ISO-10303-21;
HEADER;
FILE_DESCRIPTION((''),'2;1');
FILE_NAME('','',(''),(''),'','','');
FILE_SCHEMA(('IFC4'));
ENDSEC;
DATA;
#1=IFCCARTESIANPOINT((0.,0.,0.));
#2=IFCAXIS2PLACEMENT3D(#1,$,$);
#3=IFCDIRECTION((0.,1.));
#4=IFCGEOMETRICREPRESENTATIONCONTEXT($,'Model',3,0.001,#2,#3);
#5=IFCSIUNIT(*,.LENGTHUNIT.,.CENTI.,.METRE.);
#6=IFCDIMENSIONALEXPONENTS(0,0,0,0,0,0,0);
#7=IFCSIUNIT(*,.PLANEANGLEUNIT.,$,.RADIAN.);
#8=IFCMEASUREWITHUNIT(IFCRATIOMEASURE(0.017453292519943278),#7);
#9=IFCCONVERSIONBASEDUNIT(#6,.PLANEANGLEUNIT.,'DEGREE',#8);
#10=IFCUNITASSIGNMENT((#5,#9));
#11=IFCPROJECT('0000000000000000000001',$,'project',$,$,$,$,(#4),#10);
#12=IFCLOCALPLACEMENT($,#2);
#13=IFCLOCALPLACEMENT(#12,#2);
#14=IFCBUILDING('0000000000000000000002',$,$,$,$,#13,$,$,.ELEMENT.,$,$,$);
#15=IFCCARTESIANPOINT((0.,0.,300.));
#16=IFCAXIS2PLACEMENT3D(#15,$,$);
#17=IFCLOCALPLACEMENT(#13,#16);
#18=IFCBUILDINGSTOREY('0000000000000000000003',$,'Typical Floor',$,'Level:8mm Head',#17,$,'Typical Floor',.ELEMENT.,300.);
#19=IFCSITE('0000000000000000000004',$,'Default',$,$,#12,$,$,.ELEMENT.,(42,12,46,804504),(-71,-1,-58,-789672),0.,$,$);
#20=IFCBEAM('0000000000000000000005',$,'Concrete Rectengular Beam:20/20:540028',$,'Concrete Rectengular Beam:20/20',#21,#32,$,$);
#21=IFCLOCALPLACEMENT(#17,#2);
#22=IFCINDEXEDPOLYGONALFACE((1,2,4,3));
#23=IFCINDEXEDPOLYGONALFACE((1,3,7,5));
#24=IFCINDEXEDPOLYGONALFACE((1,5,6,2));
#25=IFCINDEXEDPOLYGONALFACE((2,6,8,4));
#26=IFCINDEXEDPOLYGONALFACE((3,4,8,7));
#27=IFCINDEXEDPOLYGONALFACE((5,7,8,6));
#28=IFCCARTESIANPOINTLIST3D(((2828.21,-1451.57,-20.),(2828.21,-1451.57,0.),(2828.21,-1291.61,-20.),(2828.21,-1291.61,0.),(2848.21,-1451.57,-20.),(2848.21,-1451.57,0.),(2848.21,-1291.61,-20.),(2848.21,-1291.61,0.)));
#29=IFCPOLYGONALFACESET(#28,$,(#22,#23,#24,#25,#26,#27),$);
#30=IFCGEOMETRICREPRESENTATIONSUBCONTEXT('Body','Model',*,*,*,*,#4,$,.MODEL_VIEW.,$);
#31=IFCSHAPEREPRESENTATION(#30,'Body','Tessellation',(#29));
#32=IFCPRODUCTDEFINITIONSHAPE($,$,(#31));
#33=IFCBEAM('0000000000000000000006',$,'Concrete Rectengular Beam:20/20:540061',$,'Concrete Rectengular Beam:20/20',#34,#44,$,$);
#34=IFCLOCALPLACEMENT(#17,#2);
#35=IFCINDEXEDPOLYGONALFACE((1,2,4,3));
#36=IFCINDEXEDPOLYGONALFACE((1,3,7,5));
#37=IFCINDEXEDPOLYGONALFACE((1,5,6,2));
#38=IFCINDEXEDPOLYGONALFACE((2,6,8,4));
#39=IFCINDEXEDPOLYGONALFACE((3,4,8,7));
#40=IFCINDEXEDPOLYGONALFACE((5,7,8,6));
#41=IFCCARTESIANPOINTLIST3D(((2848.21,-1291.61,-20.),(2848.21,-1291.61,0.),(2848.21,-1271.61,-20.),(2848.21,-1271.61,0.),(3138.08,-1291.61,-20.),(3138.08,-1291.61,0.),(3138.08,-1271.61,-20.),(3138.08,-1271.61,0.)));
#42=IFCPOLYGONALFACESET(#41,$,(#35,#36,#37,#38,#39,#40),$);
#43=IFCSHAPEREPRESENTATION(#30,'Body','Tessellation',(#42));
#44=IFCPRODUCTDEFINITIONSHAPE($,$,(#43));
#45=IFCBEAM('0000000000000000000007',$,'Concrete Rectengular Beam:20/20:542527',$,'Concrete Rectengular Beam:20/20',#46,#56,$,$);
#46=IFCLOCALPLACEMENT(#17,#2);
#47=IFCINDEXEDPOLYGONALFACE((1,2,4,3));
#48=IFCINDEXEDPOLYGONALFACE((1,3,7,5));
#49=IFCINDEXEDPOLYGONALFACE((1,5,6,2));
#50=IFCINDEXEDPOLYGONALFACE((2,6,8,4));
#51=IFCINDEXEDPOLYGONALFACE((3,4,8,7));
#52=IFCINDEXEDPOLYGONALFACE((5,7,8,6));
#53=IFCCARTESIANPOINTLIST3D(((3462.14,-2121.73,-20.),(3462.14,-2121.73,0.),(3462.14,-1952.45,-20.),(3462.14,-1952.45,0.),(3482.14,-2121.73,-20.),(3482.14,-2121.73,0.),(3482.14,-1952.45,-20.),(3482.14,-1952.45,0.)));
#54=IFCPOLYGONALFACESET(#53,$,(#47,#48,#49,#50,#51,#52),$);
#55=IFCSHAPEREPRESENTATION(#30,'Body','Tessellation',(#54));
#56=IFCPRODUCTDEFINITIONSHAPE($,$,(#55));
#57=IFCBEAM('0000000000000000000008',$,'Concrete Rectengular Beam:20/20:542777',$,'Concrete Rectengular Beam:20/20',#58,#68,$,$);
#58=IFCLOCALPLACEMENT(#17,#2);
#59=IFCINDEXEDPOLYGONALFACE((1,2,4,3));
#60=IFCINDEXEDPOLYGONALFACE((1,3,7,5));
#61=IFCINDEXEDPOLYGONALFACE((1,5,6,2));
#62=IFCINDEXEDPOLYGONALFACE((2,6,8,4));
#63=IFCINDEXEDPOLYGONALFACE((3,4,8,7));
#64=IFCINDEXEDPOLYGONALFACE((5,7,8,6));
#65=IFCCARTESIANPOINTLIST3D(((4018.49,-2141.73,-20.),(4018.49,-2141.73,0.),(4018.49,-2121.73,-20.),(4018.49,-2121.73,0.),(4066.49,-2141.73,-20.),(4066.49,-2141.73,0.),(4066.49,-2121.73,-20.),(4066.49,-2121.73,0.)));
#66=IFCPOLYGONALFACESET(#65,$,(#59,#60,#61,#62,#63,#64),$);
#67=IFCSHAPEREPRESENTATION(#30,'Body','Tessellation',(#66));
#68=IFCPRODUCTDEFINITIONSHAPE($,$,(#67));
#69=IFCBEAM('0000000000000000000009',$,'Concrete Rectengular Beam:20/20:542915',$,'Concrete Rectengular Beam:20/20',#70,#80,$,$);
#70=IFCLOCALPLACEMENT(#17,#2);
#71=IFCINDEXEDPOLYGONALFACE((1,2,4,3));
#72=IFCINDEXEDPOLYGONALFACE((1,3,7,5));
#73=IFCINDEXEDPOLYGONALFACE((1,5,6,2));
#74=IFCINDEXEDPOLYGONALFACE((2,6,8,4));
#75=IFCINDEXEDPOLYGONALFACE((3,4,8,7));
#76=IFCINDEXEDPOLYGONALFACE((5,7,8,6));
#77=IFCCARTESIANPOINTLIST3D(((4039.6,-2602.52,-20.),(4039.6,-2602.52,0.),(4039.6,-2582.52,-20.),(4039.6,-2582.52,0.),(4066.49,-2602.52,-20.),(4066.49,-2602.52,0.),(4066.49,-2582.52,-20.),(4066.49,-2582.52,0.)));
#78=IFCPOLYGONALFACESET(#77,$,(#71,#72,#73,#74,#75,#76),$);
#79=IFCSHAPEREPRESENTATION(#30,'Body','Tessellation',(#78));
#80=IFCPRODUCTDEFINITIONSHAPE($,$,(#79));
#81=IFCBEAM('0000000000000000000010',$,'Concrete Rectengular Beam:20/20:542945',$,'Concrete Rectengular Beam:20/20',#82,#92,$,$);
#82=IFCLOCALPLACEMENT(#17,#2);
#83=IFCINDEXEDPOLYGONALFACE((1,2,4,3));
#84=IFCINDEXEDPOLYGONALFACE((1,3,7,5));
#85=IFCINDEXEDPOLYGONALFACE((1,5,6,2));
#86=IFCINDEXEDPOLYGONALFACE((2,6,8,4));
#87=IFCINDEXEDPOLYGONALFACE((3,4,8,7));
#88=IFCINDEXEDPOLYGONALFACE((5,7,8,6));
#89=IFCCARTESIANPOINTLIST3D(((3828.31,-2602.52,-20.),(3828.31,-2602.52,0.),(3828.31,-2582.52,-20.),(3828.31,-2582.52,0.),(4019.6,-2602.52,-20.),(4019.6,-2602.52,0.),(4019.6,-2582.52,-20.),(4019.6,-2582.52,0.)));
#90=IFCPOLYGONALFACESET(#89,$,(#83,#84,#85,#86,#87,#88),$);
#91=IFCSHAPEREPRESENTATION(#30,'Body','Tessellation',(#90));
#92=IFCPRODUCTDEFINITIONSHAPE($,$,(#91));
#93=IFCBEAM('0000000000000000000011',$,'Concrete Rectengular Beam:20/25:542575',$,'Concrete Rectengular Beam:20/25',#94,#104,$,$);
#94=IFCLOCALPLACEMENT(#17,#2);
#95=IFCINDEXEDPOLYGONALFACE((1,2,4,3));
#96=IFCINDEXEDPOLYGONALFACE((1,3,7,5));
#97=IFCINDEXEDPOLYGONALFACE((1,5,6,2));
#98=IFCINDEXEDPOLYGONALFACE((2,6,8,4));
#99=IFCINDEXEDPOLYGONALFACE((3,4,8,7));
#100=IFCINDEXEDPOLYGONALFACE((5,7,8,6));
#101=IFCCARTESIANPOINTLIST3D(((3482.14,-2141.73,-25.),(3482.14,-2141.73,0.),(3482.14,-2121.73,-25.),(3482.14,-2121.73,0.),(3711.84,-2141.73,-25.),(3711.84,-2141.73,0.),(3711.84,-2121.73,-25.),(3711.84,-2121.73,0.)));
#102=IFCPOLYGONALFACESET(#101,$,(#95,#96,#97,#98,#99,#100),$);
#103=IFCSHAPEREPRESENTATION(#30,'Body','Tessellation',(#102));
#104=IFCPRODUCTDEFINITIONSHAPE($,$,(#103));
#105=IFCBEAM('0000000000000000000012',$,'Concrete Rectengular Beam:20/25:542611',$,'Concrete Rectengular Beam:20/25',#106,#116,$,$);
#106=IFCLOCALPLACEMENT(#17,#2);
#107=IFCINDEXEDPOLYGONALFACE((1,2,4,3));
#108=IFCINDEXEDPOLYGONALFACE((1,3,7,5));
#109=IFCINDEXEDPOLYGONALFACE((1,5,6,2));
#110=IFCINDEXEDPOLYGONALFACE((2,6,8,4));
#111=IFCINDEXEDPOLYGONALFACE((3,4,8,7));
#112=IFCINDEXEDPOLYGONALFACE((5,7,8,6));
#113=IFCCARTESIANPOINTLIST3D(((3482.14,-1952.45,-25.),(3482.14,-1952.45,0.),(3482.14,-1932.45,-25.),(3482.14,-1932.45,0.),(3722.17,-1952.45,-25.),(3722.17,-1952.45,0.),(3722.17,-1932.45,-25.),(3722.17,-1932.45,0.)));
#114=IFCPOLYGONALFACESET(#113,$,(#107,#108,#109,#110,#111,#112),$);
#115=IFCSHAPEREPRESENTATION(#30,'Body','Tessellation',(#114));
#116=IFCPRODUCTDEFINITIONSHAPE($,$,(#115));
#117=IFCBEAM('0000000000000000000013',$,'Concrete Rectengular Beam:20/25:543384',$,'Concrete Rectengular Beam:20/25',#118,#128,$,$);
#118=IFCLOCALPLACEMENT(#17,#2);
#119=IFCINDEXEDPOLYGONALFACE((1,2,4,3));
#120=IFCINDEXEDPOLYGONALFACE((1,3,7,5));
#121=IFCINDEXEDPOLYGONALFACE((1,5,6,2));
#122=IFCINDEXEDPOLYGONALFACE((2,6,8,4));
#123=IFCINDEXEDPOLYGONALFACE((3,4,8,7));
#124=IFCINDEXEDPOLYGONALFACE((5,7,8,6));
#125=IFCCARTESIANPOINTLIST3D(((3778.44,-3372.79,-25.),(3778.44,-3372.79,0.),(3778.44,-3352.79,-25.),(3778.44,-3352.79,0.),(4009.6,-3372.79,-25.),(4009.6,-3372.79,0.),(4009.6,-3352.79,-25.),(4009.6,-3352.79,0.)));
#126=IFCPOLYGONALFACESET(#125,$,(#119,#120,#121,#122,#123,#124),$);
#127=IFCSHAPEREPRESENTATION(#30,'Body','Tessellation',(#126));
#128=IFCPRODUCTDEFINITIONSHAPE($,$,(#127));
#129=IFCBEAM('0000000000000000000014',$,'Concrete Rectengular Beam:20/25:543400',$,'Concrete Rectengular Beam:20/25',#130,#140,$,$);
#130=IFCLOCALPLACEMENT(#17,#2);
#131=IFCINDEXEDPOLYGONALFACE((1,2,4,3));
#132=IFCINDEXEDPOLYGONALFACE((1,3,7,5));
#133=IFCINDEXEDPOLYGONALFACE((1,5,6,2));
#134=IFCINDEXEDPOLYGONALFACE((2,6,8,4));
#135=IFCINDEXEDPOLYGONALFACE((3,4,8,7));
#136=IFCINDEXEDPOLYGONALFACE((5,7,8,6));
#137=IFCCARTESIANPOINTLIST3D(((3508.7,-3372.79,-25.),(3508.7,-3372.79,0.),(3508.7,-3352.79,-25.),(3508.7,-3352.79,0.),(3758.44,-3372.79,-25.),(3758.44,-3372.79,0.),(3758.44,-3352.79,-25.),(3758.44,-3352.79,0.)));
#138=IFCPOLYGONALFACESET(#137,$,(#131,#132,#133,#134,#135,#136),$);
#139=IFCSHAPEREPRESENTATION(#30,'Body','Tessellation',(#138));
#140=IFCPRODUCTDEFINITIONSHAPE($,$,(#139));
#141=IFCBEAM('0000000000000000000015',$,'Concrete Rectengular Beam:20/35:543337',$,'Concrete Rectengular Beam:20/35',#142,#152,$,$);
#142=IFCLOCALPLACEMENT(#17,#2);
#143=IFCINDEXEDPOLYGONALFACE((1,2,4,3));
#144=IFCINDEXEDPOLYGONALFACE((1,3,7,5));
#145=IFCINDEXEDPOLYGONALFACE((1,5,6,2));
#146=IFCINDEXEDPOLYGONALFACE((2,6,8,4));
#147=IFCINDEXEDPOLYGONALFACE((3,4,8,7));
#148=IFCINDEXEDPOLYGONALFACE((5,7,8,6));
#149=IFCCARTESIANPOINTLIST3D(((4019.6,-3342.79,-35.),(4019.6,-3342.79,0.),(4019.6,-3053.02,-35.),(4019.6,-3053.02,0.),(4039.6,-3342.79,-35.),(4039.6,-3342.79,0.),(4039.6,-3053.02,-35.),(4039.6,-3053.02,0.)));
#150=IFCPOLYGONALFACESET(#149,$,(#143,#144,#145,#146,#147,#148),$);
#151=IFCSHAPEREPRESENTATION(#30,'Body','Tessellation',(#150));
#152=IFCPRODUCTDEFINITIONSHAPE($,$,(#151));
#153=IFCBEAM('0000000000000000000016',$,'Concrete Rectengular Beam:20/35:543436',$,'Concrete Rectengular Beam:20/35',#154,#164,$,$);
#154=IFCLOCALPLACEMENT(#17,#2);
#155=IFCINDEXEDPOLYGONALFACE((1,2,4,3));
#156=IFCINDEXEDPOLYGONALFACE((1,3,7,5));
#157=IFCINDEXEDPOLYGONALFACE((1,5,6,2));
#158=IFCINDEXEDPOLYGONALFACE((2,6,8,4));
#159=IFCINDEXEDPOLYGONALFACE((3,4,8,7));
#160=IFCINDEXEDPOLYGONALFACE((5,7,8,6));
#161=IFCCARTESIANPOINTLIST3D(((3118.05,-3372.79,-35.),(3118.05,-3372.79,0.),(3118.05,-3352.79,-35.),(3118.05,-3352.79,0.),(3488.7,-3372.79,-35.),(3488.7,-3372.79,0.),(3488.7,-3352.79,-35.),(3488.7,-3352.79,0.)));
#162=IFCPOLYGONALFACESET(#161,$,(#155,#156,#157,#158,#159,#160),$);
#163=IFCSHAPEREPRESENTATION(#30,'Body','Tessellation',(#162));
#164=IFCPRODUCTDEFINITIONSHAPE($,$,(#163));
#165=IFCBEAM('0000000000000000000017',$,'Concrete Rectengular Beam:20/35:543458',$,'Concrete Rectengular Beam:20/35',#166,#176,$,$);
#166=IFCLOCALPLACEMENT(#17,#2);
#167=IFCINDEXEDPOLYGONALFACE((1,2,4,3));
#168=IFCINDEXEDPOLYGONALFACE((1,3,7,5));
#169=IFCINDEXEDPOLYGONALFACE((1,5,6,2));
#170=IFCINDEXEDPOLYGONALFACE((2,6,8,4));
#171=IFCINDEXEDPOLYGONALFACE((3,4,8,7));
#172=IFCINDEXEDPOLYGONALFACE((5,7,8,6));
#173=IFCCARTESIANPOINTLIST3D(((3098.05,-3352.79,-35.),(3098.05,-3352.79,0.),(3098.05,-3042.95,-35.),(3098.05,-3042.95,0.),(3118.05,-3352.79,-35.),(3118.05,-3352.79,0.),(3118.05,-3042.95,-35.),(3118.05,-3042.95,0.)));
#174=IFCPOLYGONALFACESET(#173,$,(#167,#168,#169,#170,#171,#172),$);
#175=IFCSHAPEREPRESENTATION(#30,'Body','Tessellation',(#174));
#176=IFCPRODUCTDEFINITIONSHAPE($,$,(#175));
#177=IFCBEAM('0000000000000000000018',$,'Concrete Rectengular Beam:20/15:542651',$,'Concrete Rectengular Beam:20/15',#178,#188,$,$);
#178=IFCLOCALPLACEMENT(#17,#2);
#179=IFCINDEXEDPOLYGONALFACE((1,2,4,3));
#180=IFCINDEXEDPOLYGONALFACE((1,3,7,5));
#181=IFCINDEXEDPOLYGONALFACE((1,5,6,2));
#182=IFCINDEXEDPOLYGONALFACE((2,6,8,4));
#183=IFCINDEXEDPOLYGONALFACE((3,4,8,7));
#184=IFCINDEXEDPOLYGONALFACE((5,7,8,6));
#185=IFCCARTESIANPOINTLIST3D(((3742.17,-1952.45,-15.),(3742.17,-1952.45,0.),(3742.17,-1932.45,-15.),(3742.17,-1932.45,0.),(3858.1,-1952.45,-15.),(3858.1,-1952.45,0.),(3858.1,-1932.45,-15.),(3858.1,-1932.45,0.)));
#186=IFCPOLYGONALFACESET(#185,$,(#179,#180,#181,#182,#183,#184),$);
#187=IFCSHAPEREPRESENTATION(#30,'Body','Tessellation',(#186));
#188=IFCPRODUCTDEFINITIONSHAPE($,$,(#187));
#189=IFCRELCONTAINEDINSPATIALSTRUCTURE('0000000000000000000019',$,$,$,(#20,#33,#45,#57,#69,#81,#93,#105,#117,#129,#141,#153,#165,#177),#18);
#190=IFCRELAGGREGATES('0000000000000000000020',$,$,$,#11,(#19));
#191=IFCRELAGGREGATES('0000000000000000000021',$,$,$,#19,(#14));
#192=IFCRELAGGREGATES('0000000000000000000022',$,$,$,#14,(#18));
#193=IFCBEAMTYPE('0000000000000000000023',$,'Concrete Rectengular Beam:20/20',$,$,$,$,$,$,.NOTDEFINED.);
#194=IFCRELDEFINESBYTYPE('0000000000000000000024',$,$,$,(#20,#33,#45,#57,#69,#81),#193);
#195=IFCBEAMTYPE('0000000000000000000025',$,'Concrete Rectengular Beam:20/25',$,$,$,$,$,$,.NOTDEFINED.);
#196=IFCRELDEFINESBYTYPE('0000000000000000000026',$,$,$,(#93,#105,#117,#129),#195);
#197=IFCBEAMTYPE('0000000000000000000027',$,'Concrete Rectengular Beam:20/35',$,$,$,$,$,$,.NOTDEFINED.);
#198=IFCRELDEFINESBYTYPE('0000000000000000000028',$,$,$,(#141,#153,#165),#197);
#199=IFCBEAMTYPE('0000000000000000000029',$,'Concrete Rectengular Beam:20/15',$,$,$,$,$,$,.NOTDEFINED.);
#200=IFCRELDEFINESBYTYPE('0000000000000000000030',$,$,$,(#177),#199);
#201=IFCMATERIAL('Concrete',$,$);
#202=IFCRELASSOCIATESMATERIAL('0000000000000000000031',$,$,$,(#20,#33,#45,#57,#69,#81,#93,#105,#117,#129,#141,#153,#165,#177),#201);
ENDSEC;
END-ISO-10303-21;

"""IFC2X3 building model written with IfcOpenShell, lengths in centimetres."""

from ifc_helpers import new_model, entity, si_unit, converted_unit, direction, frame, frame_2d, origin, place, context, subcontext, project, spatial, rectangle, extrude, material, type_object, element, save


model = new_model("IFC2X3")

# Units and contexts
model_context = context("Model", 3, precision=0.001, world=origin(), true_north=direction((0.0, 1.0)))
body_context = subcontext(model_context, "Body", "Model", "MODEL_VIEW")
ifc_project = project(units=[si_unit("LENGTHUNIT", "METRE", prefix="CENTI"), converted_unit("PLANEANGLEUNIT", "DEGREE", entity("IfcRatioMeasure", 0.017453292519943278), si_unit("PLANEANGLEUNIT", "RADIAN"), dimensions=[0, 0, 0, 0, 0, 0, 0])], contexts=[model_context])

# Site, building, storey
site_placement = place(None, origin())
site = spatial("IfcSite", under=ifc_project, at=site_placement, Name="Default", CompositionType="ELEMENT", RefLatitude=(42, 12, 46, 804504), RefLongitude=(-71, -1, -58, -789672), RefElevation=0.0)
building_placement = place(site_placement, origin())
building = spatial("IfcBuilding", under=site, at=building_placement, CompositionType="ELEMENT")
storey_placement = place(building_placement, frame((0.0, 0.0, 300.0)))
storey = spatial("IfcBuildingStorey", under=building, at=storey_placement, Name="Typical Floor", ObjectType="Level:8mm Head", LongName="Typical Floor", CompositionType="ELEMENT", Elevation=300.0)

# Beams
ifc_material = material(Name="Concrete")
beam_type_1 = type_object("IfcBeamType", Name="Concrete Rectengular Beam:20/20", PredefinedType="NOTDEFINED")
beam_1_placement = place(storey_placement, frame((2838.21, -1281.61, 0.0), z_axis=(0.0, 0.0, 1.0), x_axis=(0.0, -1.0, 0.0)))
element("IfcBeam", 1, at=beam_1_placement, inside=storey, type_object=beam_type_1, material=ifc_material, Name="Concrete Rectengular Beam:20/20:540028", ObjectType="Concrete Rectengular Beam:20/20", context=body_context, shape_type="SweptSolid", body=[
    extrude(rectangle(XDim=20.0, YDim=20.0, at=frame_2d((0.0, 0.0), x_axis=(1.0, 0.0))), frame((10.0, 0.0, -10.0), z_axis=(1.0, 0.0, 0.0), x_axis=(0.0, 0.0, -1.0)), (0.0, 0.0, 1.0), 159.96),
])
beam_2_placement = place(storey_placement, frame((2838.21, -1281.61, 0.0)))
element("IfcBeam", 2, at=beam_2_placement, inside=storey, type_object=beam_type_1, material=ifc_material, Name="Concrete Rectengular Beam:20/20:540061", ObjectType="Concrete Rectengular Beam:20/20", context=body_context, shape_type="SweptSolid", body=[
    extrude(rectangle(XDim=20.0, YDim=20.0, at=frame_2d((0.0, 0.0), x_axis=(1.0, 0.0))), frame((10.0, 0.0, -10.0), z_axis=(1.0, 0.0, 0.0), x_axis=(0.0, 0.0, -1.0)), (0.0, 0.0, 1.0), 289.88),
])
beam_3_placement = place(storey_placement, frame((3472.14, -2131.73, 0.0), z_axis=(0.0, 0.0, 1.0), x_axis=(0.0, 1.0, 0.0)))
element("IfcBeam", 3, at=beam_3_placement, inside=storey, type_object=beam_type_1, material=ifc_material, Name="Concrete Rectengular Beam:20/20:542527", ObjectType="Concrete Rectengular Beam:20/20", context=body_context, shape_type="SweptSolid", body=[
    extrude(rectangle(XDim=20.0, YDim=20.0, at=frame_2d((0.0, 0.0), x_axis=(1.0, 0.0))), frame((10.0, 0.0, -10.0), z_axis=(1.0, 0.0, 0.0), x_axis=(0.0, 0.0, -1.0)), (0.0, 0.0, 1.0), 169.28),
])
beam_4_placement = place(storey_placement, frame((3998.49, -2131.73, 0.0)))
element("IfcBeam", 4, at=beam_4_placement, inside=storey, type_object=beam_type_1, material=ifc_material, Name="Concrete Rectengular Beam:20/20:542777", ObjectType="Concrete Rectengular Beam:20/20", context=body_context, shape_type="SweptSolid", body=[
    extrude(rectangle(XDim=20.0, YDim=20.0, at=frame_2d((0.0, 0.0), x_axis=(1.0, 0.0))), frame((20.0, 0.0, -10.0), z_axis=(1.0, 0.0, 0.0), x_axis=(0.0, 0.0, -1.0)), (0.0, 0.0, 1.0), 48.0),
])
beam_5_placement = place(storey_placement, frame((4029.6, -2592.52, 0.0)))
element("IfcBeam", 5, at=beam_5_placement, inside=storey, type_object=beam_type_1, material=ifc_material, Name="Concrete Rectengular Beam:20/20:542915", ObjectType="Concrete Rectengular Beam:20/20", context=body_context, shape_type="SweptSolid", body=[
    extrude(rectangle(XDim=20.0, YDim=20.0, at=frame_2d((0.0, 0.0), x_axis=(1.0, 0.0))), frame((10.0, 0.0, -10.0), z_axis=(1.0, 0.0, 0.0), x_axis=(0.0, 0.0, -1.0)), (0.0, 0.0, 1.0), 26.89),
])
beam_6_placement = place(storey_placement, frame((4029.6, -2592.52, 0.0), z_axis=(0.0, 0.0, 1.0), x_axis=(-1.0, 0.0, 0.0)))
element("IfcBeam", 6, at=beam_6_placement, inside=storey, type_object=beam_type_1, material=ifc_material, Name="Concrete Rectengular Beam:20/20:542945", ObjectType="Concrete Rectengular Beam:20/20", context=body_context, shape_type="SweptSolid", body=[
    extrude(rectangle(XDim=20.0, YDim=20.0, at=frame_2d((0.0, 0.0), x_axis=(1.0, 0.0))), frame((10.0, 0.0, -10.0), z_axis=(1.0, 0.0, 0.0), x_axis=(0.0, 0.0, -1.0)), (0.0, 0.0, 1.0), 191.29),
])
beam_type_2 = type_object("IfcBeamType", Name="Concrete Rectengular Beam:20/25", PredefinedType="NOTDEFINED")
beam_7_placement = place(storey_placement, frame((3472.14, -2131.73, 0.0)))
element("IfcBeam", 7, at=beam_7_placement, inside=storey, type_object=beam_type_2, material=ifc_material, Name="Concrete Rectengular Beam:20/25:542575", ObjectType="Concrete Rectengular Beam:20/25", context=body_context, shape_type="SweptSolid", body=[
    extrude(rectangle(XDim=25.0, YDim=20.0, at=frame_2d((0.0, 0.0), x_axis=(1.0, 0.0))), frame((10.0, 0.0, -12.5), z_axis=(1.0, 0.0, 0.0), x_axis=(0.0, 0.0, -1.0)), (0.0, 0.0, 1.0), 229.7),
])
beam_8_placement = place(storey_placement, frame((3472.14, -1942.45, 0.0)))
element("IfcBeam", 8, at=beam_8_placement, inside=storey, type_object=beam_type_2, material=ifc_material, Name="Concrete Rectengular Beam:20/25:542611", ObjectType="Concrete Rectengular Beam:20/25", context=body_context, shape_type="SweptSolid", body=[
    extrude(rectangle(XDim=25.0, YDim=20.0, at=frame_2d((0.0, 0.0), x_axis=(1.0, 0.0))), frame((10.0, 0.0, -12.5), z_axis=(1.0, 0.0, 0.0), x_axis=(0.0, 0.0, -1.0)), (0.0, 0.0, 1.0), 240.03),
])
beam_9_placement = place(storey_placement, frame((4029.6, -3362.79, 0.0), z_axis=(0.0, 0.0, 1.0), x_axis=(-1.0, 0.0, 0.0)))
element("IfcBeam", 9, at=beam_9_placement, inside=storey, type_object=beam_type_2, material=ifc_material, Name="Concrete Rectengular Beam:20/25:543384", ObjectType="Concrete Rectengular Beam:20/25", context=body_context, shape_type="SweptSolid", body=[
    extrude(rectangle(XDim=25.0, YDim=20.0, at=frame_2d((0.0, 0.0), x_axis=(1.0, 0.0))), frame((20.0, 0.0, -12.5), z_axis=(1.0, 0.0, 0.0), x_axis=(0.0, 0.0, -1.0)), (0.0, 0.0, 1.0), 231.16),
])
beam_10_placement = place(storey_placement, frame((3768.44, -3362.79, 0.0), z_axis=(0.0, 0.0, 1.0), x_axis=(-1.0, 0.0, 0.0)))
element("IfcBeam", 10, at=beam_10_placement, inside=storey, type_object=beam_type_2, material=ifc_material, Name="Concrete Rectengular Beam:20/25:543400", ObjectType="Concrete Rectengular Beam:20/25", context=body_context, shape_type="SweptSolid", body=[
    extrude(rectangle(XDim=25.0, YDim=20.0, at=frame_2d((0.0, 0.0), x_axis=(1.0, 0.0))), frame((10.0, 0.0, -12.5), z_axis=(1.0, 0.0, 0.0), x_axis=(0.0, 0.0, -1.0)), (0.0, 0.0, 1.0), 249.74),
])
beam_type_3 = type_object("IfcBeamType", Name="Concrete Rectengular Beam:20/35", PredefinedType="NOTDEFINED")
beam_11_placement = place(storey_placement, frame((4029.6, -3043.02, 0.0), z_axis=(0.0, 0.0, 1.0), x_axis=(0.0, -1.0, 0.0)))
element("IfcBeam", 11, at=beam_11_placement, inside=storey, type_object=beam_type_3, material=ifc_material, Name="Concrete Rectengular Beam:20/35:543337", ObjectType="Concrete Rectengular Beam:20/35", context=body_context, shape_type="SweptSolid", body=[
    extrude(rectangle(XDim=35.0, YDim=20.0, at=frame_2d((0.0, 0.0), x_axis=(1.0, 0.0))), frame((10.0, 0.0, -17.5), z_axis=(1.0, 0.0, 0.0), x_axis=(0.0, 0.0, -1.0)), (0.0, 0.0, 1.0), 289.77),
])
beam_12_placement = place(storey_placement, frame((3498.7, -3362.79, 0.0), z_axis=(0.0, 0.0, 1.0), x_axis=(-1.0, 0.0, 0.0)))
element("IfcBeam", 12, at=beam_12_placement, inside=storey, type_object=beam_type_3, material=ifc_material, Name="Concrete Rectengular Beam:20/35:543436", ObjectType="Concrete Rectengular Beam:20/35", context=body_context, shape_type="SweptSolid", body=[
    extrude(rectangle(XDim=35.0, YDim=20.0, at=frame_2d((0.0, 0.0), x_axis=(1.0, 0.0))), frame((10.0, 0.0, -17.5), z_axis=(1.0, 0.0, 0.0), x_axis=(0.0, 0.0, -1.0)), (0.0, 0.0, 1.0), 370.65),
])
beam_13_placement = place(storey_placement, frame((3108.05, -3362.79, 0.0), z_axis=(0.0, 0.0, 1.0), x_axis=(0.0, 1.0, 0.0)))
element("IfcBeam", 13, at=beam_13_placement, inside=storey, type_object=beam_type_3, material=ifc_material, Name="Concrete Rectengular Beam:20/35:543458", ObjectType="Concrete Rectengular Beam:20/35", context=body_context, shape_type="SweptSolid", body=[
    extrude(rectangle(XDim=35.0, YDim=20.0, at=frame_2d((0.0, 0.0), x_axis=(1.0, 0.0))), frame((10.0, 0.0, -17.5), z_axis=(1.0, 0.0, 0.0), x_axis=(0.0, 0.0, -1.0)), (0.0, 0.0, 1.0), 309.83),
])
beam_type_4 = type_object("IfcBeamType", Name="Concrete Rectengular Beam:20/15", PredefinedType="NOTDEFINED")
beam_14_placement = place(storey_placement, frame((3732.17, -1942.45, 0.0)))
element("IfcBeam", 14, at=beam_14_placement, inside=storey, type_object=beam_type_4, material=ifc_material, Name="Concrete Rectengular Beam:20/15:542651", ObjectType="Concrete Rectengular Beam:20/15", context=body_context, shape_type="SweptSolid", body=[
    extrude(rectangle(XDim=15.0, YDim=20.0, at=frame_2d((0.0, 0.0), x_axis=(1.0, 0.0))), frame((10.0, 0.0, -7.5), z_axis=(1.0, 0.0, 0.0), x_axis=(0.0, 0.0, -1.0)), (0.0, 0.0, 1.0), 115.93),
])

save(model, "model.ifc")
